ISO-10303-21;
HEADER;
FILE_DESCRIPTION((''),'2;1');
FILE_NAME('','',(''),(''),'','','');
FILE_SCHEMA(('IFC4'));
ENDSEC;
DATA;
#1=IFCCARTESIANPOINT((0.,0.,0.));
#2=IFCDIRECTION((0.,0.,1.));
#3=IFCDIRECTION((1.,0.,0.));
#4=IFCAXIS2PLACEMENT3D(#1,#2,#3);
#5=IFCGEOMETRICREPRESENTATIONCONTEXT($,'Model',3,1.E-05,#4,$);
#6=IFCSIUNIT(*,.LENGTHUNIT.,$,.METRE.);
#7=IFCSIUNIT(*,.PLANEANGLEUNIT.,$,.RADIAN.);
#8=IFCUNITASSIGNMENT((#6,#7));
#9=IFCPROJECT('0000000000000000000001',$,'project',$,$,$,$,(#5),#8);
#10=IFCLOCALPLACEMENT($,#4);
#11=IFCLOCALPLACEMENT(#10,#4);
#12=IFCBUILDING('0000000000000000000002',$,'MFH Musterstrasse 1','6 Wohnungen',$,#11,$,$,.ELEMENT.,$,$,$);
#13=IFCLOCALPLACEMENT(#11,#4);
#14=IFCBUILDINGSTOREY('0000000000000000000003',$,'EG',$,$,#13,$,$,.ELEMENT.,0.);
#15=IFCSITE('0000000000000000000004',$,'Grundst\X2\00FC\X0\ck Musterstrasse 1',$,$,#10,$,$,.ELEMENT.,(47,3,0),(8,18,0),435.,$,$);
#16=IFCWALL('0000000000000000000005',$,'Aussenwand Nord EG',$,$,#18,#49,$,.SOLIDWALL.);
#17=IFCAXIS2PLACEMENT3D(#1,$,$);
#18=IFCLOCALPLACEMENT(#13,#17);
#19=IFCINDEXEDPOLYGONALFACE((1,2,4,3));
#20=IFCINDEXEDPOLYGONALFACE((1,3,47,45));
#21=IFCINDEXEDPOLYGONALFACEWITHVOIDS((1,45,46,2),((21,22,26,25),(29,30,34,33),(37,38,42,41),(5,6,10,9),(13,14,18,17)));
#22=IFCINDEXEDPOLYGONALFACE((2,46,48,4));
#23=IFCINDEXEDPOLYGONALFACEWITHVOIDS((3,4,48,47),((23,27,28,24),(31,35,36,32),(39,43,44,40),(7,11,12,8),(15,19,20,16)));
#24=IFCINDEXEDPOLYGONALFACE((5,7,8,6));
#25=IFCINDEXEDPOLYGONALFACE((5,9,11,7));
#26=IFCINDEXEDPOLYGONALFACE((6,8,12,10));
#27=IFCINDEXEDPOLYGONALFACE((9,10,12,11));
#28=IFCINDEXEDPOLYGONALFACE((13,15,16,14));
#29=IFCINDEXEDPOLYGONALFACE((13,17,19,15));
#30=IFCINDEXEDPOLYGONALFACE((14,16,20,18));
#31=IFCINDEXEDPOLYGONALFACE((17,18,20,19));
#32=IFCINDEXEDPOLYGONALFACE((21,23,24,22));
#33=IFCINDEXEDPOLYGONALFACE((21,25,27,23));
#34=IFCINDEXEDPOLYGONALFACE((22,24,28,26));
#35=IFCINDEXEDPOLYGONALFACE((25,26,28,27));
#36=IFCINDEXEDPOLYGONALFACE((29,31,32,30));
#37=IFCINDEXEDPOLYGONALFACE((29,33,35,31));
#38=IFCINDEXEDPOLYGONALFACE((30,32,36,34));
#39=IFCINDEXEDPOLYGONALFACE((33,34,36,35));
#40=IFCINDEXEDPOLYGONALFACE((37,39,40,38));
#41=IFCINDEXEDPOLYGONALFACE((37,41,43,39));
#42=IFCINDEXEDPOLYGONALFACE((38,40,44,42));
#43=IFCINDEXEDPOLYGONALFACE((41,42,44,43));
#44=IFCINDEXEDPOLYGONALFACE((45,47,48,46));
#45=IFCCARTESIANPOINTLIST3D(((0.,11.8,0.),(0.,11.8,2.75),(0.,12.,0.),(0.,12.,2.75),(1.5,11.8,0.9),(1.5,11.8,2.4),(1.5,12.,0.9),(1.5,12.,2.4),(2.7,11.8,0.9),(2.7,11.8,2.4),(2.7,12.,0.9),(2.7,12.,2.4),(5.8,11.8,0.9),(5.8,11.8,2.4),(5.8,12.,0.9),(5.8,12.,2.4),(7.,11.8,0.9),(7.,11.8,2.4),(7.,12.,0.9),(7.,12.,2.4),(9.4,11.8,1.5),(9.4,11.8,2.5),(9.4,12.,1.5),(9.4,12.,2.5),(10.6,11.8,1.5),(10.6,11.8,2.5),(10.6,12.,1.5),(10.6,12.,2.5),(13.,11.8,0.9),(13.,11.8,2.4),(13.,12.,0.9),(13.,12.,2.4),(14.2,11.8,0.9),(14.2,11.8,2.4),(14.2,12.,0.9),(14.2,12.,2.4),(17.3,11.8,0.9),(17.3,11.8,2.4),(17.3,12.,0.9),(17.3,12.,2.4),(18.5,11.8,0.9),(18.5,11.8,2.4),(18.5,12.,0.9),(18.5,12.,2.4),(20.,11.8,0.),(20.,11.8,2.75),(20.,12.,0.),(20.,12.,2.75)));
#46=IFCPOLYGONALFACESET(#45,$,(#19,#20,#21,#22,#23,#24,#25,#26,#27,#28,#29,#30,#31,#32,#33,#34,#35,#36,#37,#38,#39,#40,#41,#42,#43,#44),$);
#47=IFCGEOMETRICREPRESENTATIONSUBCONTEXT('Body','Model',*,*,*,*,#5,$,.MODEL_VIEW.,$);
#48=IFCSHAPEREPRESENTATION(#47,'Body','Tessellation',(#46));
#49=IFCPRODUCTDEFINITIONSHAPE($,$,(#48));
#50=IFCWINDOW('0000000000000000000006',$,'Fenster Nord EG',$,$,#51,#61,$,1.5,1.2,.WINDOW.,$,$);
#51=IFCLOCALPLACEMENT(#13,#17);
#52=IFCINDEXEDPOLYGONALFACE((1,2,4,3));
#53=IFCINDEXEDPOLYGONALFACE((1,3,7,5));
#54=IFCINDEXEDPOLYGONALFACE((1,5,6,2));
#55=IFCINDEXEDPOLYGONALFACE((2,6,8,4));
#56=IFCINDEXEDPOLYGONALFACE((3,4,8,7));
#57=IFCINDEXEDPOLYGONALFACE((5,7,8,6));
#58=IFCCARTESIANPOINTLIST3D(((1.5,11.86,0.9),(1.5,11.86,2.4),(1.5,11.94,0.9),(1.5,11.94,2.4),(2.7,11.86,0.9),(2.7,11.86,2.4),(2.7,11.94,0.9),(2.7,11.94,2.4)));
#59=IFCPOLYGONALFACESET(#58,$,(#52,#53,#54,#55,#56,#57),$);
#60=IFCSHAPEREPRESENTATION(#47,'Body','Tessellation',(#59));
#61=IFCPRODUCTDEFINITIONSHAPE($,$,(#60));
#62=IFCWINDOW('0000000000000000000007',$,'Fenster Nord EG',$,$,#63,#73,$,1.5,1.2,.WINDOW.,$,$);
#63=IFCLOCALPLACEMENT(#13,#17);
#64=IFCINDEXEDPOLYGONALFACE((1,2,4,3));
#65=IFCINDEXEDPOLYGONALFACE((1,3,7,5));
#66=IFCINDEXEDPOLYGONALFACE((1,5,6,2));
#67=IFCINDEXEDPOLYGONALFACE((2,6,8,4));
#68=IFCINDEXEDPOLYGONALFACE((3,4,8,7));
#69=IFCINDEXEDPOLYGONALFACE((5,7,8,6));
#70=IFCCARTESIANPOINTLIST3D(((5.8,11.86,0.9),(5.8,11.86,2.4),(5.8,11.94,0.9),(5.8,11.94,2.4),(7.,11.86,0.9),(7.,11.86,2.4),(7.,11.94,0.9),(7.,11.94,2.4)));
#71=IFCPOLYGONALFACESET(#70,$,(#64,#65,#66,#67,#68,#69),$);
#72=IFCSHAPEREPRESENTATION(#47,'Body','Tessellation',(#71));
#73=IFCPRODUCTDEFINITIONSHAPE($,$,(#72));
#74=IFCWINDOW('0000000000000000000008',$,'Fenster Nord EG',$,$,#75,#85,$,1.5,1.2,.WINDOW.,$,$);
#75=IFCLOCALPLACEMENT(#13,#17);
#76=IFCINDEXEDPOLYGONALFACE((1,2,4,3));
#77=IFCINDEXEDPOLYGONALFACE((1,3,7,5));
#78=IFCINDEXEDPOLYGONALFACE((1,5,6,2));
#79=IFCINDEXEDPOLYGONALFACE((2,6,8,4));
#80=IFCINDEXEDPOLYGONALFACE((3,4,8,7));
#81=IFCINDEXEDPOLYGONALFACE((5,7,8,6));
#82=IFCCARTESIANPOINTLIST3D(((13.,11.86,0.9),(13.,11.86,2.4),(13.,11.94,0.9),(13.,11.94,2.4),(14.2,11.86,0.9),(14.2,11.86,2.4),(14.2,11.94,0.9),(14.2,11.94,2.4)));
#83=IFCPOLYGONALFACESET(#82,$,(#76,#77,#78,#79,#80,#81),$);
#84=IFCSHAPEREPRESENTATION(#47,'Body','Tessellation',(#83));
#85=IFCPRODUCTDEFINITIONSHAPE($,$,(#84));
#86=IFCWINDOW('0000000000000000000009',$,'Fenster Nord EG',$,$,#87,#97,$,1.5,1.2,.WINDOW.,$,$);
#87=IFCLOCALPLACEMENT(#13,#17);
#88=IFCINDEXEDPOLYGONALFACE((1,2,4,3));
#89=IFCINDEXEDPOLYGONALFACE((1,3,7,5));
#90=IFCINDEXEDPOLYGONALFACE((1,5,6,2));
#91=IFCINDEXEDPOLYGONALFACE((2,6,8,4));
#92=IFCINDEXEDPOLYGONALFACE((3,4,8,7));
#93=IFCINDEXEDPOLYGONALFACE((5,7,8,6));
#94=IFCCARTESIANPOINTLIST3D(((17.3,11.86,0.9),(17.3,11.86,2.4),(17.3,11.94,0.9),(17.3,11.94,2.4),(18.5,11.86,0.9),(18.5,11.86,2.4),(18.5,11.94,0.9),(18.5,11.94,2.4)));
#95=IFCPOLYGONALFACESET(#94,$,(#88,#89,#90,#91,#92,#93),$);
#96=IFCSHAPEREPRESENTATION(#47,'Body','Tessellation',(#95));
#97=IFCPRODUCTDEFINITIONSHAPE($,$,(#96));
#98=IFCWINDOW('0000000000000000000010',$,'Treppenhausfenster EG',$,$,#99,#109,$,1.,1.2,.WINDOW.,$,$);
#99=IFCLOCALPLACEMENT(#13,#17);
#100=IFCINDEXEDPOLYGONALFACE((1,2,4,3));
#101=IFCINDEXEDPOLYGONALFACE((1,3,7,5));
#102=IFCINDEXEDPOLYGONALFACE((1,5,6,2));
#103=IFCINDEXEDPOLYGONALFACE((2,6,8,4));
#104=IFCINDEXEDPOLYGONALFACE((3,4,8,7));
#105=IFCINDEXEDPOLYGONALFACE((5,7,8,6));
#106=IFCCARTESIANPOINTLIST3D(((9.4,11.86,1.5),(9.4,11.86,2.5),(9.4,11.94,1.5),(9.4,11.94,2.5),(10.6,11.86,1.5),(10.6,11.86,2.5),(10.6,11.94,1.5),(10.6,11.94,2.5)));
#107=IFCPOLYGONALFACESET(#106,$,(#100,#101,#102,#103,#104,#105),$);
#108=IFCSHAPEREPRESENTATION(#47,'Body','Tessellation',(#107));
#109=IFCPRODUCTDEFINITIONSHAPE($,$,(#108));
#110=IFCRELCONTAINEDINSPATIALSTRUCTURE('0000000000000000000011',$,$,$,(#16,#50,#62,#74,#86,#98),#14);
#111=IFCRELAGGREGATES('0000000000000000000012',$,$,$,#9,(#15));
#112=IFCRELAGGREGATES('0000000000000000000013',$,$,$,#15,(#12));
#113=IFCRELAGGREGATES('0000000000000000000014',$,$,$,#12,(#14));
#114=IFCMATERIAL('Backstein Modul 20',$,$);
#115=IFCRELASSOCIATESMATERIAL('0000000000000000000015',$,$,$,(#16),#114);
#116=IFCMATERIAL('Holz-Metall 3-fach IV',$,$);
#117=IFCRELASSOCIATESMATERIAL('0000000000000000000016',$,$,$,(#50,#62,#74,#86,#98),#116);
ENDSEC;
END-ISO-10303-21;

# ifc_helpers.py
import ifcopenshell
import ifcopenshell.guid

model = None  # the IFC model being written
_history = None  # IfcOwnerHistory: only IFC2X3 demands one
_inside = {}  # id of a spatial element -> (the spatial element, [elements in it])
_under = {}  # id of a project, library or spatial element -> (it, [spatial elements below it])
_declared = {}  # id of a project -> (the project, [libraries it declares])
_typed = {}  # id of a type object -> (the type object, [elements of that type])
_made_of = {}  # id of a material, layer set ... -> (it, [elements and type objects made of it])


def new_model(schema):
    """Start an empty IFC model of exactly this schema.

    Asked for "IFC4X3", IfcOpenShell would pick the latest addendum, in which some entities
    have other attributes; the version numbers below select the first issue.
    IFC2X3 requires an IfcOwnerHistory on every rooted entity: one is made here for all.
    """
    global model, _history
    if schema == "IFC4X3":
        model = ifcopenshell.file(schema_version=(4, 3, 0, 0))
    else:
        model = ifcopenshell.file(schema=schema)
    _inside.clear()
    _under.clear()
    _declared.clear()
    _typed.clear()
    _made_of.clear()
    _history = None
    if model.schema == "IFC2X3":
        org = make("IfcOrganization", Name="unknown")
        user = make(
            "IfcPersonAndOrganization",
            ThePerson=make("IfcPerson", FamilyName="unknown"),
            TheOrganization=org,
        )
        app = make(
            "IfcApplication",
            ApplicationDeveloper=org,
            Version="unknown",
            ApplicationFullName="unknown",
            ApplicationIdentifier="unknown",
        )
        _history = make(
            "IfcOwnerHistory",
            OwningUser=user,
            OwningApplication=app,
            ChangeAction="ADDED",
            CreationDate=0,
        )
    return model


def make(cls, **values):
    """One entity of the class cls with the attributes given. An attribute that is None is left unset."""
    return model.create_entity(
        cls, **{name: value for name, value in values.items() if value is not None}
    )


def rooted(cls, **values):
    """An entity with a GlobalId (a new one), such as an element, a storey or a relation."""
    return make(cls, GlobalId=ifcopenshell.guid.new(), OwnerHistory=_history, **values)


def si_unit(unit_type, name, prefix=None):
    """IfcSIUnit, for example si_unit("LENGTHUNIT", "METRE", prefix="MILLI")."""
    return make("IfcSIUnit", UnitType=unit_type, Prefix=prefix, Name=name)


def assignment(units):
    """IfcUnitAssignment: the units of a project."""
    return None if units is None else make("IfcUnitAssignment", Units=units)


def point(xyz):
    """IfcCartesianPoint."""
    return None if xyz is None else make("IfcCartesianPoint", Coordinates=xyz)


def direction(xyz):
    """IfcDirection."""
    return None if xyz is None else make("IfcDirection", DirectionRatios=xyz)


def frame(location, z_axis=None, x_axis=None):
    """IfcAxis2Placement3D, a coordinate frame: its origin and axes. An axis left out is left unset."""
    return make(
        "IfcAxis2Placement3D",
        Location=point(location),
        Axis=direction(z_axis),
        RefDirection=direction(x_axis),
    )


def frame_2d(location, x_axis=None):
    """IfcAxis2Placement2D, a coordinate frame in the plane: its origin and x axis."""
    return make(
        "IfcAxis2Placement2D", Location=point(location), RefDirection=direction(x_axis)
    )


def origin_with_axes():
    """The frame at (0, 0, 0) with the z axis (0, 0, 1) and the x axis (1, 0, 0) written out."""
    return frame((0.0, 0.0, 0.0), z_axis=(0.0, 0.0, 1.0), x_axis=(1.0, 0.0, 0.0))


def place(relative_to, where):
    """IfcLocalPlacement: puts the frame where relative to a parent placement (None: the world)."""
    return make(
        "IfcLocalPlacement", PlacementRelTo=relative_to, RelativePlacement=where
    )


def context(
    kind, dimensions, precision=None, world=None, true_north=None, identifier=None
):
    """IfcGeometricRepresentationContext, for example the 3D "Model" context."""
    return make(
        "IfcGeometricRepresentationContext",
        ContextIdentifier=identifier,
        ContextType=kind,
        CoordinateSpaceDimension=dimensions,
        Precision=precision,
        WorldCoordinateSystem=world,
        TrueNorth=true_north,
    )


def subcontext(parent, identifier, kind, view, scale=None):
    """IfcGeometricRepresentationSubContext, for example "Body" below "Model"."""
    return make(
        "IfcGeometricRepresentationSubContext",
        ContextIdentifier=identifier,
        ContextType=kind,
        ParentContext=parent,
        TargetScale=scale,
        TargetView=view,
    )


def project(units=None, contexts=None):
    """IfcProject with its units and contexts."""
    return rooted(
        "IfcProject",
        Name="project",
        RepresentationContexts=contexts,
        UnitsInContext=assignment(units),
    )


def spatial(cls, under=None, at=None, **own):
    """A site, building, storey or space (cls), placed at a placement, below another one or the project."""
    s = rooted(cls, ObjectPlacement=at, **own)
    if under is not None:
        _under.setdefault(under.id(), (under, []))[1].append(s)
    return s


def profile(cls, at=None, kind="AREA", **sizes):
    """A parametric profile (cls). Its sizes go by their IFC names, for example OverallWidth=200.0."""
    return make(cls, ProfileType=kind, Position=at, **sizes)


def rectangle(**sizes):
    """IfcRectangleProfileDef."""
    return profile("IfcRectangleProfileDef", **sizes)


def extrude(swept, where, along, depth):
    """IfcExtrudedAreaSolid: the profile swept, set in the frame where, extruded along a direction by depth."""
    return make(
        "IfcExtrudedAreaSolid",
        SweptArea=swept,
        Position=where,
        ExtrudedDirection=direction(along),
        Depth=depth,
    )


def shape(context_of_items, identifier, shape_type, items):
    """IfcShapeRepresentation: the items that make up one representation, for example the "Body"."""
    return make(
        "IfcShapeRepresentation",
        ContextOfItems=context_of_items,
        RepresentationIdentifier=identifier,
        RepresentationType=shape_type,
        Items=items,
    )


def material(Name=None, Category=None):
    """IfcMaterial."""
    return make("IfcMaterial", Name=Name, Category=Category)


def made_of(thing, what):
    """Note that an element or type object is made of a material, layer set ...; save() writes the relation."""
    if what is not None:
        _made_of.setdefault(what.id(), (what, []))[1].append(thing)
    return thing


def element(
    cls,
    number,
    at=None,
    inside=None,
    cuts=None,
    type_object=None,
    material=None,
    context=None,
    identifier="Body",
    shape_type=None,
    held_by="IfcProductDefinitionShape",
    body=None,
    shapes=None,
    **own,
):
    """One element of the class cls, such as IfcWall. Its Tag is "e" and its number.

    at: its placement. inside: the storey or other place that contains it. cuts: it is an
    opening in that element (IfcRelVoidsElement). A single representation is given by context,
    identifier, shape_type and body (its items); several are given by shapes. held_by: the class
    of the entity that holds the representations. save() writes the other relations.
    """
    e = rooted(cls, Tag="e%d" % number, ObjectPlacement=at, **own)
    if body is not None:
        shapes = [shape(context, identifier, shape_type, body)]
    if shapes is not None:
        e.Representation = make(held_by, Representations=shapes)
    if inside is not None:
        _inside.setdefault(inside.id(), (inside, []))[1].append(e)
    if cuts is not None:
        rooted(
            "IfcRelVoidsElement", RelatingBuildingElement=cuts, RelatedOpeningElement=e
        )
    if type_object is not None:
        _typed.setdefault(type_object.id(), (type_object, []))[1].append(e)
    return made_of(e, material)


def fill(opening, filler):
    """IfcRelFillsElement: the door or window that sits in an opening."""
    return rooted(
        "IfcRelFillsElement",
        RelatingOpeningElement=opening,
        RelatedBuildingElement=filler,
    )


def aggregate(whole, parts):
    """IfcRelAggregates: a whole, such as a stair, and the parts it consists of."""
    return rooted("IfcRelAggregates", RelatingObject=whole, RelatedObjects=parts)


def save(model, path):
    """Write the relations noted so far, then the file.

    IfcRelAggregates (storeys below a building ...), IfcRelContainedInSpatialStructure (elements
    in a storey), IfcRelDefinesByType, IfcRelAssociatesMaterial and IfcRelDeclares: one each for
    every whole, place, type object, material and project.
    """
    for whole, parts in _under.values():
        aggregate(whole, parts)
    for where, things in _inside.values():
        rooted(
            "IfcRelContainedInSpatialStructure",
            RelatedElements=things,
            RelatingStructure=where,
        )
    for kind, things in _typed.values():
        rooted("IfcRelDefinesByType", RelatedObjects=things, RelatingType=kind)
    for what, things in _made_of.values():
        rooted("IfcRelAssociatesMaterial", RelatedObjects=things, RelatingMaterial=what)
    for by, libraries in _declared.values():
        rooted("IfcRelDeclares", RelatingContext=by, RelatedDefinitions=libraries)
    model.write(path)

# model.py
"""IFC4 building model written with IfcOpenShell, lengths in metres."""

from ifc_helpers import new_model, si_unit, frame, frame_2d, origin_with_axes, place, context, subcontext, project, spatial, rectangle, extrude, material, element, fill, save


model = new_model("IFC4")

# Units and contexts
model_context = context("Model", 3, precision=1e-05, world=origin_with_axes())
body_context = subcontext(model_context, "Body", "Model", "MODEL_VIEW")
ifc_project = project(units=[si_unit("LENGTHUNIT", "METRE"), si_unit("PLANEANGLEUNIT", "RADIAN")], contexts=[model_context])

# Site, building, storey
site_placement = place(None, origin_with_axes())
site = spatial("IfcSite", under=ifc_project, at=site_placement, Name="Grundstück Musterstrasse 1", CompositionType="ELEMENT", RefLatitude=(47, 3, 0), RefLongitude=(8, 18, 0), RefElevation=435.0)
building_placement = place(site_placement, origin_with_axes())
building = spatial("IfcBuilding", under=site, at=building_placement, Name="MFH Musterstrasse 1", Description="6 Wohnungen", CompositionType="ELEMENT")
storey_placement = place(building_placement, origin_with_axes())
storey = spatial("IfcBuildingStorey", under=building, at=storey_placement, Name="EG", CompositionType="ELEMENT", Elevation=0.0)

# Shared definitions
ifc_material_1 = material(Name="Backstein Modul 20")
ifc_material_2 = material(Name="Holz-Metall 3-fach IV")

# Wall, openings, windows
wall_1_placement = place(storey_placement, origin_with_axes())
wall_1 = element("IfcWall", 1, at=wall_1_placement, inside=storey, material=ifc_material_1, Name="Aussenwand Nord EG", PredefinedType="SOLIDWALL", context=body_context, shape_type="SweptSolid", body=[
    extrude(rectangle(XDim=20.0, YDim=0.2, at=frame_2d((10.0, 0.1), x_axis=(1.0, 0.0))), frame((0.0, 11.8, 0.0), z_axis=(0.0, 0.0, 1.0), x_axis=(1.0, 0.0, 0.0)), (0.0, 0.0, 1.0), 2.75),
])
opening_1_placement = place(storey_placement, origin_with_axes())
element("IfcOpeningElement", 2, at=opening_1_placement, cuts=wall_1, PredefinedType="OPENING", context=body_context, shape_type="SweptSolid", body=[
    extrude(rectangle(XDim=1.2, YDim=0.3, at=frame_2d((0.6, 0.15), x_axis=(1.0, 0.0))), frame((1.5, 11.75, 0.9), z_axis=(0.0, 0.0, 1.0), x_axis=(1.0, 0.0, 0.0)), (0.0, 0.0, 1.0), 1.5),
])
opening_2_placement = place(storey_placement, origin_with_axes())
element("IfcOpeningElement", 3, at=opening_2_placement, cuts=wall_1, PredefinedType="OPENING", context=body_context, shape_type="SweptSolid", body=[
    extrude(rectangle(XDim=1.2, YDim=0.3, at=frame_2d((0.6, 0.15), x_axis=(1.0, 0.0))), frame((5.8, 11.75, 0.9), z_axis=(0.0, 0.0, 1.0), x_axis=(1.0, 0.0, 0.0)), (0.0, 0.0, 1.0), 1.5),
])
opening_3_placement = place(storey_placement, origin_with_axes())
element("IfcOpeningElement", 4, at=opening_3_placement, cuts=wall_1, PredefinedType="OPENING", context=body_context, shape_type="SweptSolid", body=[
    extrude(rectangle(XDim=1.2, YDim=0.3, at=frame_2d((0.6, 0.15), x_axis=(1.0, 0.0))), frame((13.0, 11.75, 0.9), z_axis=(0.0, 0.0, 1.0), x_axis=(1.0, 0.0, 0.0)), (0.0, 0.0, 1.0), 1.5),
])
opening_4_placement = place(storey_placement, origin_with_axes())
element("IfcOpeningElement", 5, at=opening_4_placement, cuts=wall_1, PredefinedType="OPENING", context=body_context, shape_type="SweptSolid", body=[
    extrude(rectangle(XDim=1.2, YDim=0.3, at=frame_2d((0.6, 0.15), x_axis=(1.0, 0.0))), frame((17.3, 11.75, 0.9), z_axis=(0.0, 0.0, 1.0), x_axis=(1.0, 0.0, 0.0)), (0.0, 0.0, 1.0), 1.5),
])
opening_5_placement = place(storey_placement, origin_with_axes())
element("IfcOpeningElement", 6, at=opening_5_placement, cuts=wall_1, PredefinedType="OPENING", context=body_context, shape_type="SweptSolid", body=[
    extrude(rectangle(XDim=1.2, YDim=0.3, at=frame_2d((0.6, 0.15), x_axis=(1.0, 0.0))), frame((9.4, 11.75, 1.5), z_axis=(0.0, 0.0, 1.0), x_axis=(1.0, 0.0, 0.0)), (0.0, 0.0, 1.0), 1.0),
])
opening_6_placement = place(storey_placement, origin_with_axes())
opening_6 = element("IfcOpeningElement", 7, at=opening_6_placement, cuts=wall_1, PredefinedType="OPENING", context=body_context, shape_type="SweptSolid", body=[
    extrude(rectangle(XDim=1.2, YDim=0.22, at=frame_2d((0.6, 0.11), x_axis=(1.0, 0.0))), frame((1.5, 11.79, 0.9), z_axis=(0.0, 0.0, 1.0), x_axis=(1.0, 0.0, 0.0)), (0.0, 0.0, 1.0), 1.5),
])
opening_7_placement = place(storey_placement, origin_with_axes())
opening_7 = element("IfcOpeningElement", 8, at=opening_7_placement, cuts=wall_1, PredefinedType="OPENING", context=body_context, shape_type="SweptSolid", body=[
    extrude(rectangle(XDim=1.2, YDim=0.22, at=frame_2d((0.6, 0.11), x_axis=(1.0, 0.0))), frame((5.8, 11.79, 0.9), z_axis=(0.0, 0.0, 1.0), x_axis=(1.0, 0.0, 0.0)), (0.0, 0.0, 1.0), 1.5),
])
opening_8_placement = place(storey_placement, origin_with_axes())
opening_8 = element("IfcOpeningElement", 9, at=opening_8_placement, cuts=wall_1, PredefinedType="OPENING", context=body_context, shape_type="SweptSolid", body=[
    extrude(rectangle(XDim=1.2, YDim=0.22, at=frame_2d((0.6, 0.11), x_axis=(1.0, 0.0))), frame((13.0, 11.79, 0.9), z_axis=(0.0, 0.0, 1.0), x_axis=(1.0, 0.0, 0.0)), (0.0, 0.0, 1.0), 1.5),
])
opening_9_placement = place(storey_placement, origin_with_axes())
opening_9 = element("IfcOpeningElement", 10, at=opening_9_placement, cuts=wall_1, PredefinedType="OPENING", context=body_context, shape_type="SweptSolid", body=[
    extrude(rectangle(XDim=1.2, YDim=0.22, at=frame_2d((0.6, 0.11), x_axis=(1.0, 0.0))), frame((17.3, 11.79, 0.9), z_axis=(0.0, 0.0, 1.0), x_axis=(1.0, 0.0, 0.0)), (0.0, 0.0, 1.0), 1.5),
])
opening_10_placement = place(storey_placement, origin_with_axes())
opening_10 = element("IfcOpeningElement", 11, at=opening_10_placement, cuts=wall_1, PredefinedType="OPENING", context=body_context, shape_type="SweptSolid", body=[
    extrude(rectangle(XDim=1.2, YDim=0.22, at=frame_2d((0.6, 0.11), x_axis=(1.0, 0.0))), frame((9.4, 11.79, 1.5), z_axis=(0.0, 0.0, 1.0), x_axis=(1.0, 0.0, 0.0)), (0.0, 0.0, 1.0), 1.0),
])
window_1_placement = place(storey_placement, origin_with_axes())
window_1 = element("IfcWindow", 12, at=window_1_placement, inside=storey, material=ifc_material_2, Name="Fenster Nord EG", OverallHeight=1.5, OverallWidth=1.2, PredefinedType="WINDOW", context=body_context, shape_type="SweptSolid", body=[
    extrude(rectangle(XDim=1.2, YDim=0.08, at=frame_2d((0.6, 0.04), x_axis=(1.0, 0.0))), frame((1.5, 11.86, 0.9), z_axis=(0.0, 0.0, 1.0), x_axis=(1.0, 0.0, 0.0)), (0.0, 0.0, 1.0), 1.5),
])
fill(opening_6, window_1)
window_2_placement = place(storey_placement, origin_with_axes())
window_2 = element("IfcWindow", 13, at=window_2_placement, inside=storey, material=ifc_material_2, Name="Fenster Nord EG", OverallHeight=1.5, OverallWidth=1.2, PredefinedType="WINDOW", context=body_context, shape_type="SweptSolid", body=[
    extrude(rectangle(XDim=1.2, YDim=0.08, at=frame_2d((0.6, 0.04), x_axis=(1.0, 0.0))), frame((5.8, 11.86, 0.9), z_axis=(0.0, 0.0, 1.0), x_axis=(1.0, 0.0, 0.0)), (0.0, 0.0, 1.0), 1.5),
])
fill(opening_7, window_2)
window_3_placement = place(storey_placement, origin_with_axes())
window_3 = element("IfcWindow", 14, at=window_3_placement, inside=storey, material=ifc_material_2, Name="Fenster Nord EG", OverallHeight=1.5, OverallWidth=1.2, PredefinedType="WINDOW", context=body_context, shape_type="SweptSolid", body=[
    extrude(rectangle(XDim=1.2, YDim=0.08, at=frame_2d((0.6, 0.04), x_axis=(1.0, 0.0))), frame((13.0, 11.86, 0.9), z_axis=(0.0, 0.0, 1.0), x_axis=(1.0, 0.0, 0.0)), (0.0, 0.0, 1.0), 1.5),
])
fill(opening_8, window_3)
window_4_placement = place(storey_placement, origin_with_axes())
window_4 = element("IfcWindow", 15, at=window_4_placement, inside=storey, material=ifc_material_2, Name="Fenster Nord EG", OverallHeight=1.5, OverallWidth=1.2, PredefinedType="WINDOW", context=body_context, shape_type="SweptSolid", body=[
    extrude(rectangle(XDim=1.2, YDim=0.08, at=frame_2d((0.6, 0.04), x_axis=(1.0, 0.0))), frame((17.3, 11.86, 0.9), z_axis=(0.0, 0.0, 1.0), x_axis=(1.0, 0.0, 0.0)), (0.0, 0.0, 1.0), 1.5),
])
fill(opening_9, window_4)
window_5_placement = place(storey_placement, origin_with_axes())
window_5 = element("IfcWindow", 16, at=window_5_placement, inside=storey, material=ifc_material_2, Name="Treppenhausfenster EG", OverallHeight=1.0, OverallWidth=1.2, PredefinedType="WINDOW", context=body_context, shape_type="SweptSolid", body=[
    extrude(rectangle(XDim=1.2, YDim=0.08, at=frame_2d((0.6, 0.04), x_axis=(1.0, 0.0))), frame((9.4, 11.86, 1.5), z_axis=(0.0, 0.0, 1.0), x_axis=(1.0, 0.0, 0.0)), (0.0, 0.0, 1.0), 1.0),
])
fill(opening_10, window_5)

save(model, "model.ifc")
